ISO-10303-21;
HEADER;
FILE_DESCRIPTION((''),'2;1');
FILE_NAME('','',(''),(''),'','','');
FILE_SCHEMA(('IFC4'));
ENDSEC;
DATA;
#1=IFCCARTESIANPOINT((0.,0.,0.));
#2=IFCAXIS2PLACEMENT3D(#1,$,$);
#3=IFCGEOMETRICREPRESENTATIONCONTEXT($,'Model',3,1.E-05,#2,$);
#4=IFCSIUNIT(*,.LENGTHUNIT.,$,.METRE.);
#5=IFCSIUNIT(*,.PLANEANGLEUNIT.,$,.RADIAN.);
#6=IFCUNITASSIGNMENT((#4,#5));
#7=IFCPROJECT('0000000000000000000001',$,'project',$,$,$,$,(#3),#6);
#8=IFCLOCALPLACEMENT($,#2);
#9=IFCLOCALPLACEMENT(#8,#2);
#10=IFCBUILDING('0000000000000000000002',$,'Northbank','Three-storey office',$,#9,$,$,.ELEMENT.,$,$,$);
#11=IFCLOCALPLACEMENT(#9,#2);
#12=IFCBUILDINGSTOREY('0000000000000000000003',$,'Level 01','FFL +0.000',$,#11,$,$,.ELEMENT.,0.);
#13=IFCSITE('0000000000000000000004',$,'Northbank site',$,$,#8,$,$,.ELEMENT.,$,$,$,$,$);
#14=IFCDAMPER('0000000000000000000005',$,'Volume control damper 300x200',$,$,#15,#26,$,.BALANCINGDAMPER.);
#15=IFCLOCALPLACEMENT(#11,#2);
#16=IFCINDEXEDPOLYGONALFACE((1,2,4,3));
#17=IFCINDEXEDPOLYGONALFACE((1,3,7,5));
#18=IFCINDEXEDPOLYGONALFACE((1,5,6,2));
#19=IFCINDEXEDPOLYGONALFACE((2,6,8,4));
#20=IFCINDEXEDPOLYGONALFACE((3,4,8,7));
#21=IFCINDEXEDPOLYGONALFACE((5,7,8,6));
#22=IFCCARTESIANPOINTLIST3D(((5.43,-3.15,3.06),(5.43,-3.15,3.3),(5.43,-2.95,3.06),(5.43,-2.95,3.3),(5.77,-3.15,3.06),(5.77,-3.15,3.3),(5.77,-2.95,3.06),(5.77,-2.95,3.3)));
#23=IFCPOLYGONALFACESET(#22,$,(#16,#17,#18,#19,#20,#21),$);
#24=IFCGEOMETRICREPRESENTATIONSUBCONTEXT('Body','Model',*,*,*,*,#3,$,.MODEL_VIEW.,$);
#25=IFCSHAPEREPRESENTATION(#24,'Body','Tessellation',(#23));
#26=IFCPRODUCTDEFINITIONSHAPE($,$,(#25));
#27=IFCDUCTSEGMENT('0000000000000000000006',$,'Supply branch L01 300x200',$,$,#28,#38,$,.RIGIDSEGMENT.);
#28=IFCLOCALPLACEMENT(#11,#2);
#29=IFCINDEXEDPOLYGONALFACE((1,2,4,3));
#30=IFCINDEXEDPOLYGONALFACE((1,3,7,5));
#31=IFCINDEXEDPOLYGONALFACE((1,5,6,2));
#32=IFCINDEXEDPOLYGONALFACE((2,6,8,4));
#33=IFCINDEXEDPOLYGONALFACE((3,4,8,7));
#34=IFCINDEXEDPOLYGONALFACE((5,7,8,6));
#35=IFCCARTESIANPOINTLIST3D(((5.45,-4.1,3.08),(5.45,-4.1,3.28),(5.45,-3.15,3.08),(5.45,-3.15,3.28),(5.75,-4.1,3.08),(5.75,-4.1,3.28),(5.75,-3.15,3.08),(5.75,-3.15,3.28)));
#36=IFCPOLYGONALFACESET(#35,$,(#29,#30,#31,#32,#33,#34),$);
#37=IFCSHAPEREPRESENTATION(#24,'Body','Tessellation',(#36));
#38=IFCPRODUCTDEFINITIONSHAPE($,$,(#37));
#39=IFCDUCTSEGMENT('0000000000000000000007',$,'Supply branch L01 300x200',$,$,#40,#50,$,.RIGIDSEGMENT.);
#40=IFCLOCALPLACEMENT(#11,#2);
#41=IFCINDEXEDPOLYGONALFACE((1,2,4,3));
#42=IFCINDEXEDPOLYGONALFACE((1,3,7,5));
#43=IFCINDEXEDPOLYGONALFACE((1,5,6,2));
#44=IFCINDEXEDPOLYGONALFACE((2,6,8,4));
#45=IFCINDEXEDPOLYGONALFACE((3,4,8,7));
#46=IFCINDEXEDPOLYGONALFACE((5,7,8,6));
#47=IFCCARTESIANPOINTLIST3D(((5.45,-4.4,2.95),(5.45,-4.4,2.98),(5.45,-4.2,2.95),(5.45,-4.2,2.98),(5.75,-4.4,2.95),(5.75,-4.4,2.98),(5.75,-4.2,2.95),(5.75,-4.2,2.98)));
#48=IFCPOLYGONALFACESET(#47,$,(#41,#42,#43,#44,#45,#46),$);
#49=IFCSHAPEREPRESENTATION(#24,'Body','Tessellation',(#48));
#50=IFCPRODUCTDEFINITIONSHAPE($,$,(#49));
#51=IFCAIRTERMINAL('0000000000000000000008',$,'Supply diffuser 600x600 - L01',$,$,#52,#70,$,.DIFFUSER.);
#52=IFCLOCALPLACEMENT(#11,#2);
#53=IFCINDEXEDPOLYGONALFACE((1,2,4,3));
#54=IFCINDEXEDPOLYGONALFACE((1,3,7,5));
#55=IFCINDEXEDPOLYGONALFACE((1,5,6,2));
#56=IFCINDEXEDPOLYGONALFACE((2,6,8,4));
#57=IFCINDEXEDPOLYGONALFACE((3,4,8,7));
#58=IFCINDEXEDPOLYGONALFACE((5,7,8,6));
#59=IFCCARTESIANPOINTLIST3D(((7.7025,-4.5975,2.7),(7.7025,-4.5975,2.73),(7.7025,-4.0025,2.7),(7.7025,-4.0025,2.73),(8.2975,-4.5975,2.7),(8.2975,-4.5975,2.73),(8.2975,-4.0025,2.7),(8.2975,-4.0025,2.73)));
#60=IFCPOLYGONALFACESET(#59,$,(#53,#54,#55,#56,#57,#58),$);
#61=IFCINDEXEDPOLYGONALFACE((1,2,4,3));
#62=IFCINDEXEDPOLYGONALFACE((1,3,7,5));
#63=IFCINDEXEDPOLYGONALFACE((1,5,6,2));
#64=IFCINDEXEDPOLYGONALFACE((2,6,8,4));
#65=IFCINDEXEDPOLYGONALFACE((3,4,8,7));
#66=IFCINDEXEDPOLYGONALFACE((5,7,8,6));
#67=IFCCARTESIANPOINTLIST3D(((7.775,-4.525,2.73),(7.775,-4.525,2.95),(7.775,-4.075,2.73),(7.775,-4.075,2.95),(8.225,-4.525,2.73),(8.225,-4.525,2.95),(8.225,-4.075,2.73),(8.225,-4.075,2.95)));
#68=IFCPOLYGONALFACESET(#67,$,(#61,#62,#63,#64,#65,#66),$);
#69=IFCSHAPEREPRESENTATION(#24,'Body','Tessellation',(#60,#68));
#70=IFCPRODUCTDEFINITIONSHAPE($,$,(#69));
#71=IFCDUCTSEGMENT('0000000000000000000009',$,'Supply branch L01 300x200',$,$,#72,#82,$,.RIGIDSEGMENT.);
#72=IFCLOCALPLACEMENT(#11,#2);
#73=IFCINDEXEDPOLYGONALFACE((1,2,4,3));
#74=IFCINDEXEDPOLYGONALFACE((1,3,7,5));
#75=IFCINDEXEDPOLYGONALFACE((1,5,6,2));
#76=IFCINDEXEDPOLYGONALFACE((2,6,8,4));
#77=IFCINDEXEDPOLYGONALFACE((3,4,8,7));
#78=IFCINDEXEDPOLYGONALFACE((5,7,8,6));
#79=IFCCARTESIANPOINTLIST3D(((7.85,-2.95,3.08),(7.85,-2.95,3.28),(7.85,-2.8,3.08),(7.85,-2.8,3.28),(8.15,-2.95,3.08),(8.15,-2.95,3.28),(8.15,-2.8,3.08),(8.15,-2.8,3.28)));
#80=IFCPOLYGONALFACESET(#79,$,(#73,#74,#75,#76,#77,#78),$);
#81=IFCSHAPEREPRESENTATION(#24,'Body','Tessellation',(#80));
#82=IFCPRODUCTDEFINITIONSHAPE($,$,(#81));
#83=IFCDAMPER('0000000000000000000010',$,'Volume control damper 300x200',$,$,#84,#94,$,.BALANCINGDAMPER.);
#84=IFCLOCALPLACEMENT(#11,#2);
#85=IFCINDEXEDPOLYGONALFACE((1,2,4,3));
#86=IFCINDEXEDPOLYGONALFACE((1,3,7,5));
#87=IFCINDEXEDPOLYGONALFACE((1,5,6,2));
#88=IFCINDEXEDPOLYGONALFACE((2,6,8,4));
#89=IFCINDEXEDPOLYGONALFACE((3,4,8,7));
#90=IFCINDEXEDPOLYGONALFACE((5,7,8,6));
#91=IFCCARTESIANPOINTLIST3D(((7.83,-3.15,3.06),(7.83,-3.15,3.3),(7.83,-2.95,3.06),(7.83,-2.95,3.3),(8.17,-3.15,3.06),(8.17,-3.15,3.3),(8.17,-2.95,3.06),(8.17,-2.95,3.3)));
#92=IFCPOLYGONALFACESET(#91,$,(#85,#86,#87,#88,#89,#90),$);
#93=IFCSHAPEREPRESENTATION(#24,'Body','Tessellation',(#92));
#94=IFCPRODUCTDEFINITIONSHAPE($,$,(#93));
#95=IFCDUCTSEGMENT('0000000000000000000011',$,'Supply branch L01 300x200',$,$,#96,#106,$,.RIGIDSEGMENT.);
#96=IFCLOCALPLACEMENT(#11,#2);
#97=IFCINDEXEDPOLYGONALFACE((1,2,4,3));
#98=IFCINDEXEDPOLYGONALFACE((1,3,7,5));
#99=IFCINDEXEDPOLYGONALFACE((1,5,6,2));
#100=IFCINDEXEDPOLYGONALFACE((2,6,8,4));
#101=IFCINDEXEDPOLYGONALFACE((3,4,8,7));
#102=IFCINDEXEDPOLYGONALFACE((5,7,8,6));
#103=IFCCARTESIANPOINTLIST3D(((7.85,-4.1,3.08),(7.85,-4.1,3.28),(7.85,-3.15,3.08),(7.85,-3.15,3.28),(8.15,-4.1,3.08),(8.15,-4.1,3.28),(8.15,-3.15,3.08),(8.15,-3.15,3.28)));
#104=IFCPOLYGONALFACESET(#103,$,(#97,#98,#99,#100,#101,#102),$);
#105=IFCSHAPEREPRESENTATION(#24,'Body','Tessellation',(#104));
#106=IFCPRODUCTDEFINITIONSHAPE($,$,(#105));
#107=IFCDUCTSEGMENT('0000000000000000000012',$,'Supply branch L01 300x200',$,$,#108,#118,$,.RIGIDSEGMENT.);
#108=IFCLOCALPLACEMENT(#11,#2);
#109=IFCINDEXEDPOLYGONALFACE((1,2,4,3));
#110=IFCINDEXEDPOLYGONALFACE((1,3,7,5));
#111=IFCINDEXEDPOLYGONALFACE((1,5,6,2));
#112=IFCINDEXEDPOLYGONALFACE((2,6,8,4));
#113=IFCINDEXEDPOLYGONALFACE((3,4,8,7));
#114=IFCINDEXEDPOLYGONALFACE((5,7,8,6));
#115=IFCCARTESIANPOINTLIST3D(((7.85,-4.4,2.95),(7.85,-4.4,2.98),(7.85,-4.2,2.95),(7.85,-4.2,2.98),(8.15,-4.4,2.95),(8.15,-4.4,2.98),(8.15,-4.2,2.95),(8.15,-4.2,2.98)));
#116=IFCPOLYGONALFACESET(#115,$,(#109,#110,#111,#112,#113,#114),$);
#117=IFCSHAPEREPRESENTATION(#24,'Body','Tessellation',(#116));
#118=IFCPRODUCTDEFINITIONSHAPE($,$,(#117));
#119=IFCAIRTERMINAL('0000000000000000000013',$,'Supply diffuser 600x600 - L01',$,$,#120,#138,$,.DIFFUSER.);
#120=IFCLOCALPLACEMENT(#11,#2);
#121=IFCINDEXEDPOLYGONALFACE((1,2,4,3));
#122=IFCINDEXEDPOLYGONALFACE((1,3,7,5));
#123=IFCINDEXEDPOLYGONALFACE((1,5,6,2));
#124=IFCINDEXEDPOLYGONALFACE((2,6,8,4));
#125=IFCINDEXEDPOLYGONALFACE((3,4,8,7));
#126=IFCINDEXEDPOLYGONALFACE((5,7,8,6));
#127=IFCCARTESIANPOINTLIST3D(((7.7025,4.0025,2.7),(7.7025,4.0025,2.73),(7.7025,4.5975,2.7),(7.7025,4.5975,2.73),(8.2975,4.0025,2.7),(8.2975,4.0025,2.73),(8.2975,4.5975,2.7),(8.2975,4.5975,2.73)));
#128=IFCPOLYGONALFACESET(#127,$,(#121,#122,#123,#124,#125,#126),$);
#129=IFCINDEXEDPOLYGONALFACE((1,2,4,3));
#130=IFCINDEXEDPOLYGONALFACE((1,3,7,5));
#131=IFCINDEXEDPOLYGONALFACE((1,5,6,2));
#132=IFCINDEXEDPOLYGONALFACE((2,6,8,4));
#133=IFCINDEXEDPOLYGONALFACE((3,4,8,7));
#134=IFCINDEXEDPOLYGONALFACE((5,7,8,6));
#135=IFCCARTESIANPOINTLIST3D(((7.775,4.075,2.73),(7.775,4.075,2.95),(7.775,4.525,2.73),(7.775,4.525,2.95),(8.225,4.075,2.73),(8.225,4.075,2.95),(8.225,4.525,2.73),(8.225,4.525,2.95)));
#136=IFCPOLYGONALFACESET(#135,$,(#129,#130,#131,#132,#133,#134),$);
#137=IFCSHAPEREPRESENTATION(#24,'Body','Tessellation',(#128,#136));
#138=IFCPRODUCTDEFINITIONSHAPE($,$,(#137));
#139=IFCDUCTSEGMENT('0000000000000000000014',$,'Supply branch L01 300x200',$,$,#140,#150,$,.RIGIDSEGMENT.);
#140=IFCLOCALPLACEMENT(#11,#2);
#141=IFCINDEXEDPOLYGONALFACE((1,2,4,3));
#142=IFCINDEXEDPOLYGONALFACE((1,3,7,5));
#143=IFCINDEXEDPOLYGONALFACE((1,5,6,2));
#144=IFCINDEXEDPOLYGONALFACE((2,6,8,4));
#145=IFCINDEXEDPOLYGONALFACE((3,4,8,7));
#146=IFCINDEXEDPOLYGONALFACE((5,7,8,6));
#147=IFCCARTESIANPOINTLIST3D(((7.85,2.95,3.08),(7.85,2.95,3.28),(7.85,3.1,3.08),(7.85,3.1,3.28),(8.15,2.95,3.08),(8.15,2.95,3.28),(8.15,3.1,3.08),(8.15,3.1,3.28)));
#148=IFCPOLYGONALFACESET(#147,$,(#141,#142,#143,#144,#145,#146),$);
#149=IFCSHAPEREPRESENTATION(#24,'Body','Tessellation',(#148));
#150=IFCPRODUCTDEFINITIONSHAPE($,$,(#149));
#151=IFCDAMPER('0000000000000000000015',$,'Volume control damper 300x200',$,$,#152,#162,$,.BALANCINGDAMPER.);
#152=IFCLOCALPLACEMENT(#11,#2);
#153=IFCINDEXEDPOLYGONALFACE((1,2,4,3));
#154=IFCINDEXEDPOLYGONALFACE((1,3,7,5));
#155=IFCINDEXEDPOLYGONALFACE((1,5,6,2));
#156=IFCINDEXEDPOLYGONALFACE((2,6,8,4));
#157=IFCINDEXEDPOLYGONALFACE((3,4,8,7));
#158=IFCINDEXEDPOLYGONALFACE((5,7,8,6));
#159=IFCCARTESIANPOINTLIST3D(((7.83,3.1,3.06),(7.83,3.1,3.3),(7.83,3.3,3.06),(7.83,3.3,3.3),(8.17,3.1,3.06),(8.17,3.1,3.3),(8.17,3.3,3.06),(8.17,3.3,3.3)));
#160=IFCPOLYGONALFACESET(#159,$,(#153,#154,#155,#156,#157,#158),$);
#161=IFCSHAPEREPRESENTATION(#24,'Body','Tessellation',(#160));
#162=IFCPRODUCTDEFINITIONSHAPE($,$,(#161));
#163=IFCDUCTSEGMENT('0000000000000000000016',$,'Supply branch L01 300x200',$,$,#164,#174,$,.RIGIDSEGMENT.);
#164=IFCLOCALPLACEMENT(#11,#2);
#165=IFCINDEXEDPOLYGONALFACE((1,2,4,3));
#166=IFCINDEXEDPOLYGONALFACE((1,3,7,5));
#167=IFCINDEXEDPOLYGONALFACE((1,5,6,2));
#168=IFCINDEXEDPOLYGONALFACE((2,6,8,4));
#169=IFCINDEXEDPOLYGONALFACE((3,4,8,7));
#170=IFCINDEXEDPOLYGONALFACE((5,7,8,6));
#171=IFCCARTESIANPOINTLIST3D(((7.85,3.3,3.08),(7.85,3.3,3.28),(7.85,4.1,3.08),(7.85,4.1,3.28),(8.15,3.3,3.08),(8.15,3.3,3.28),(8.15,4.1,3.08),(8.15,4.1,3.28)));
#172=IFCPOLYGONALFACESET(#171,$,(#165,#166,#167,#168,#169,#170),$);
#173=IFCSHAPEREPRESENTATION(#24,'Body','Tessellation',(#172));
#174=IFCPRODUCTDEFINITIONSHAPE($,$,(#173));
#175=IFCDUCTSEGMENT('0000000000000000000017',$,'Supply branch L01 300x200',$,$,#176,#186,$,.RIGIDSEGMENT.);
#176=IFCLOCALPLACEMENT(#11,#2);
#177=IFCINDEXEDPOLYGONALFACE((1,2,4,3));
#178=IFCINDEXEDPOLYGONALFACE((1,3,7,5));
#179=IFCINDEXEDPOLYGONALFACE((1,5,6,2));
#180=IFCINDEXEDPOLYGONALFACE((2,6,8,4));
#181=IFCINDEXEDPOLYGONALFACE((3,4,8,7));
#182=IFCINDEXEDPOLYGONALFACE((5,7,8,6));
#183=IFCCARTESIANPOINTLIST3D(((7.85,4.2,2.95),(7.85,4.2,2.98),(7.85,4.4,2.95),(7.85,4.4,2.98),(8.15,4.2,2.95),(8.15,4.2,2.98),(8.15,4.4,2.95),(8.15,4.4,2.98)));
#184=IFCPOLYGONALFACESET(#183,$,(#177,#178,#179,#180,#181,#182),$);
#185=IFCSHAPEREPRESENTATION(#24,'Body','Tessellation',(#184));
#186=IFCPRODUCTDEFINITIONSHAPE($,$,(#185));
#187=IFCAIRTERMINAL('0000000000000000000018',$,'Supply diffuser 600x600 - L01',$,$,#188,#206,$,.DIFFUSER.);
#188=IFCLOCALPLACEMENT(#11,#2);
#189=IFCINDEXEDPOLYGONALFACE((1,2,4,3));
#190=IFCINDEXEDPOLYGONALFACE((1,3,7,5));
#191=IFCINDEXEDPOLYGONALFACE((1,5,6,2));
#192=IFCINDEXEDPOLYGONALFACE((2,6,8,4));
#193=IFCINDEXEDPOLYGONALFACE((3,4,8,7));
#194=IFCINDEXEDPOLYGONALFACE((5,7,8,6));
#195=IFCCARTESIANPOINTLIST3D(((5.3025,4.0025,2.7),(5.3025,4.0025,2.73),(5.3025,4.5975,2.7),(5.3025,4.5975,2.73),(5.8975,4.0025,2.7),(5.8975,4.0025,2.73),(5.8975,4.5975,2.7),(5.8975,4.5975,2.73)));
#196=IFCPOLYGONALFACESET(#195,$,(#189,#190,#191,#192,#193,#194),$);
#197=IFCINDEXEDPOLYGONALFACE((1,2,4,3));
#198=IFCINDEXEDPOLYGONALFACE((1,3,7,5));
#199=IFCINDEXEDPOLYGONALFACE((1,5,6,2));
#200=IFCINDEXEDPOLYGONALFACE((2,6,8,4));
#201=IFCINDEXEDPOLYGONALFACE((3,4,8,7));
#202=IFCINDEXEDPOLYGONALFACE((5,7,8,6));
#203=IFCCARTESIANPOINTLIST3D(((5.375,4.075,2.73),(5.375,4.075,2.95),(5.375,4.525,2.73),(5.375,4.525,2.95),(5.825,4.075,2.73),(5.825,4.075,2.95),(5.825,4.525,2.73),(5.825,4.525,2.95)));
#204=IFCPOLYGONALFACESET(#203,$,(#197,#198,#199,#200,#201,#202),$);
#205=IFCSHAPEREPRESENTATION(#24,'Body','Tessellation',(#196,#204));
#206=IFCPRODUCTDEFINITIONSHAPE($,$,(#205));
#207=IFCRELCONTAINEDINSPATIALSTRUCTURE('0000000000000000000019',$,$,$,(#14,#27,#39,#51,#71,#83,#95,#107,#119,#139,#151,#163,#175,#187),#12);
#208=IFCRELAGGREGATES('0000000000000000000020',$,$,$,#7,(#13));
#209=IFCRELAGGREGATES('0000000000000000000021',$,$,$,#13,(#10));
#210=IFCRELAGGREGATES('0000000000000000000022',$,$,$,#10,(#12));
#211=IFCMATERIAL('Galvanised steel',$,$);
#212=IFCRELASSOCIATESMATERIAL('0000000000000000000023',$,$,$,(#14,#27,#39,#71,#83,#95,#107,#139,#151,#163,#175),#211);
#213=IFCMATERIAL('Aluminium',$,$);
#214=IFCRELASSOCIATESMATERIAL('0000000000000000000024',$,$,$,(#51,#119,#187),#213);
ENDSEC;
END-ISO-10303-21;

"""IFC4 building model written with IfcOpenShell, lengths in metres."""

from ifc_helpers import new_model, si_unit, frame, origin, place, context, subcontext, project, spatial, rectangle, extrude, material, element, save


model = new_model("IFC4")

# Units and contexts
model_context = context("Model", 3, precision=1e-05, world=origin())
body_context = subcontext(model_context, "Body", "Model", "MODEL_VIEW")
ifc_project = project(units=[si_unit("LENGTHUNIT", "METRE"), si_unit("PLANEANGLEUNIT", "RADIAN")], contexts=[model_context])

# Site, building, storey
site_placement = place(None, origin())
site = spatial("IfcSite", under=ifc_project, at=site_placement, Name="Northbank site", CompositionType="ELEMENT")
building_placement = place(site_placement, origin())
building = spatial("IfcBuilding", under=site, at=building_placement, Name="Northbank", Description="Three-storey office", CompositionType="ELEMENT")
storey_placement = place(building_placement, origin())
storey = spatial("IfcBuildingStorey", under=building, at=storey_placement, Name="Level 01", Description="FFL +0.000", CompositionType="ELEMENT", Elevation=0.0)

# Shared definitions
ifc_material_1 = material(Name="Galvanised steel")

# Shared definitions
ifc_material_2 = material(Name="Aluminium")

# Damper
damper_1_placement = place(storey_placement, origin())
element("IfcDamper", 1, at=damper_1_placement, inside=storey, material=ifc_material_1, Name="Volume control damper 300x200", PredefinedType="BALANCINGDAMPER", context=body_context, shape_type="SweptSolid", body=[
    extrude(rectangle(XDim=0.34, YDim=0.24), frame((5.6, -2.95, 3.18), z_axis=(0.0, -1.0, 0.0), x_axis=(1.0, 0.0, 0.0)), (0.0, 0.0, 1.0), 0.2),
])

# Duct segments
duct_segment_1_placement = place(storey_placement, origin())
element("IfcDuctSegment", 2, at=duct_segment_1_placement, inside=storey, material=ifc_material_1, Name="Supply branch L01 300x200", PredefinedType="RIGIDSEGMENT", context=body_context, shape_type="SweptSolid", body=[
    extrude(rectangle(XDim=0.3, YDim=0.2), frame((5.6, -3.15, 3.18), z_axis=(0.0, -1.0, 0.0), x_axis=(1.0, 0.0, 0.0)), (0.0, 0.0, 1.0), 0.95),
])
duct_segment_2_placement = place(storey_placement, origin())
element("IfcDuctSegment", 3, at=duct_segment_2_placement, inside=storey, material=ifc_material_1, Name="Supply branch L01 300x200", PredefinedType="RIGIDSEGMENT", context=body_context, shape_type="SweptSolid", body=[
    extrude(rectangle(XDim=0.3, YDim=0.2), frame((5.6, -4.3, 2.98), z_axis=(0.0, 0.0, -1.0), x_axis=(1.0, 0.0, 0.0)), (0.0, 0.0, 1.0), 0.03),
])

# Air terminal
air_terminal_1_placement = place(storey_placement, origin())
element("IfcAirTerminal", 4, at=air_terminal_1_placement, inside=storey, material=ifc_material_2, Name="Supply diffuser 600x600 - L01", PredefinedType="DIFFUSER", context=body_context, shape_type="SweptSolid", body=[
    extrude(rectangle(XDim=0.595, YDim=0.595), frame((8.0, -4.3, 2.7)), (0.0, 0.0, 1.0), 0.03),
    extrude(rectangle(XDim=0.45, YDim=0.45), frame((8.0, -4.3, 2.73)), (0.0, 0.0, 1.0), 0.22),
])

# Duct segment
duct_segment_3_placement = place(storey_placement, origin())
element("IfcDuctSegment", 5, at=duct_segment_3_placement, inside=storey, material=ifc_material_1, Name="Supply branch L01 300x200", PredefinedType="RIGIDSEGMENT", context=body_context, shape_type="SweptSolid", body=[
    extrude(rectangle(XDim=0.3, YDim=0.2), frame((8.0, -2.8, 3.18), z_axis=(0.0, -1.0, 0.0), x_axis=(1.0, 0.0, 0.0)), (0.0, 0.0, 1.0), 0.15),
])

# Damper
damper_2_placement = place(storey_placement, origin())
element("IfcDamper", 6, at=damper_2_placement, inside=storey, material=ifc_material_1, Name="Volume control damper 300x200", PredefinedType="BALANCINGDAMPER", context=body_context, shape_type="SweptSolid", body=[
    extrude(rectangle(XDim=0.34, YDim=0.24), frame((8.0, -2.95, 3.18), z_axis=(0.0, -1.0, 0.0), x_axis=(1.0, 0.0, 0.0)), (0.0, 0.0, 1.0), 0.2),
])

# Duct segments
duct_segment_4_placement = place(storey_placement, origin())
element("IfcDuctSegment", 7, at=duct_segment_4_placement, inside=storey, material=ifc_material_1, Name="Supply branch L01 300x200", PredefinedType="RIGIDSEGMENT", context=body_context, shape_type="SweptSolid", body=[
    extrude(rectangle(XDim=0.3, YDim=0.2), frame((8.0, -3.15, 3.18), z_axis=(0.0, -1.0, 0.0), x_axis=(1.0, 0.0, 0.0)), (0.0, 0.0, 1.0), 0.95),
])
duct_segment_5_placement = place(storey_placement, origin())
element("IfcDuctSegment", 8, at=duct_segment_5_placement, inside=storey, material=ifc_material_1, Name="Supply branch L01 300x200", PredefinedType="RIGIDSEGMENT", context=body_context, shape_type="SweptSolid", body=[
    extrude(rectangle(XDim=0.3, YDim=0.2), frame((8.0, -4.3, 2.98), z_axis=(0.0, 0.0, -1.0), x_axis=(1.0, 0.0, 0.0)), (0.0, 0.0, 1.0), 0.03),
])

# Air terminal
air_terminal_2_placement = place(storey_placement, origin())
element("IfcAirTerminal", 9, at=air_terminal_2_placement, inside=storey, material=ifc_material_2, Name="Supply diffuser 600x600 - L01", PredefinedType="DIFFUSER", context=body_context, shape_type="SweptSolid", body=[
    extrude(rectangle(XDim=0.595, YDim=0.595), frame((8.0, 4.3, 2.7)), (0.0, 0.0, 1.0), 0.03),
    extrude(rectangle(XDim=0.45, YDim=0.45), frame((8.0, 4.3, 2.73)), (0.0, 0.0, 1.0), 0.22),
])

# Duct segment
duct_segment_6_placement = place(storey_placement, origin())
element("IfcDuctSegment", 10, at=duct_segment_6_placement, inside=storey, material=ifc_material_1, Name="Supply branch L01 300x200", PredefinedType="RIGIDSEGMENT", context=body_context, shape_type="SweptSolid", body=[
    extrude(rectangle(XDim=0.3, YDim=0.2), frame((8.0, 2.95, 3.18), z_axis=(0.0, 1.0, 0.0), x_axis=(-1.0, 0.0, 0.0)), (0.0, 0.0, 1.0), 0.15),
])

# Damper
damper_3_placement = place(storey_placement, origin())
element("IfcDamper", 11, at=damper_3_placement, inside=storey, material=ifc_material_1, Name="Volume control damper 300x200", PredefinedType="BALANCINGDAMPER", context=body_context, shape_type="SweptSolid", body=[
    extrude(rectangle(XDim=0.34, YDim=0.24), frame((8.0, 3.1, 3.18), z_axis=(0.0, 1.0, 0.0), x_axis=(-1.0, 0.0, 0.0)), (0.0, 0.0, 1.0), 0.2),
])

# Duct segments
duct_segment_7_placement = place(storey_placement, origin())
element("IfcDuctSegment", 12, at=duct_segment_7_placement, inside=storey, material=ifc_material_1, Name="Supply branch L01 300x200", PredefinedType="RIGIDSEGMENT", context=body_context, shape_type="SweptSolid", body=[
    extrude(rectangle(XDim=0.3, YDim=0.2), frame((8.0, 3.3, 3.18), z_axis=(0.0, 1.0, 0.0), x_axis=(-1.0, 0.0, 0.0)), (0.0, 0.0, 1.0), 0.8),
])
duct_segment_8_placement = place(storey_placement, origin())
element("IfcDuctSegment", 13, at=duct_segment_8_placement, inside=storey, material=ifc_material_1, Name="Supply branch L01 300x200", PredefinedType="RIGIDSEGMENT", context=body_context, shape_type="SweptSolid", body=[
    extrude(rectangle(XDim=0.3, YDim=0.2), frame((8.0, 4.3, 2.98), z_axis=(0.0, 0.0, -1.0), x_axis=(-1.0, 0.0, 0.0)), (0.0, 0.0, 1.0), 0.03),
])

# Air terminal
air_terminal_3_placement = place(storey_placement, origin())
element("IfcAirTerminal", 14, at=air_terminal_3_placement, inside=storey, material=ifc_material_2, Name="Supply diffuser 600x600 - L01", PredefinedType="DIFFUSER", context=body_context, shape_type="SweptSolid", body=[
    extrude(rectangle(XDim=0.595, YDim=0.595), frame((5.6, 4.3, 2.7)), (0.0, 0.0, 1.0), 0.03),
    extrude(rectangle(XDim=0.45, YDim=0.45), frame((5.6, 4.3, 2.73)), (0.0, 0.0, 1.0), 0.22),
])

save(model, "model.ifc")
